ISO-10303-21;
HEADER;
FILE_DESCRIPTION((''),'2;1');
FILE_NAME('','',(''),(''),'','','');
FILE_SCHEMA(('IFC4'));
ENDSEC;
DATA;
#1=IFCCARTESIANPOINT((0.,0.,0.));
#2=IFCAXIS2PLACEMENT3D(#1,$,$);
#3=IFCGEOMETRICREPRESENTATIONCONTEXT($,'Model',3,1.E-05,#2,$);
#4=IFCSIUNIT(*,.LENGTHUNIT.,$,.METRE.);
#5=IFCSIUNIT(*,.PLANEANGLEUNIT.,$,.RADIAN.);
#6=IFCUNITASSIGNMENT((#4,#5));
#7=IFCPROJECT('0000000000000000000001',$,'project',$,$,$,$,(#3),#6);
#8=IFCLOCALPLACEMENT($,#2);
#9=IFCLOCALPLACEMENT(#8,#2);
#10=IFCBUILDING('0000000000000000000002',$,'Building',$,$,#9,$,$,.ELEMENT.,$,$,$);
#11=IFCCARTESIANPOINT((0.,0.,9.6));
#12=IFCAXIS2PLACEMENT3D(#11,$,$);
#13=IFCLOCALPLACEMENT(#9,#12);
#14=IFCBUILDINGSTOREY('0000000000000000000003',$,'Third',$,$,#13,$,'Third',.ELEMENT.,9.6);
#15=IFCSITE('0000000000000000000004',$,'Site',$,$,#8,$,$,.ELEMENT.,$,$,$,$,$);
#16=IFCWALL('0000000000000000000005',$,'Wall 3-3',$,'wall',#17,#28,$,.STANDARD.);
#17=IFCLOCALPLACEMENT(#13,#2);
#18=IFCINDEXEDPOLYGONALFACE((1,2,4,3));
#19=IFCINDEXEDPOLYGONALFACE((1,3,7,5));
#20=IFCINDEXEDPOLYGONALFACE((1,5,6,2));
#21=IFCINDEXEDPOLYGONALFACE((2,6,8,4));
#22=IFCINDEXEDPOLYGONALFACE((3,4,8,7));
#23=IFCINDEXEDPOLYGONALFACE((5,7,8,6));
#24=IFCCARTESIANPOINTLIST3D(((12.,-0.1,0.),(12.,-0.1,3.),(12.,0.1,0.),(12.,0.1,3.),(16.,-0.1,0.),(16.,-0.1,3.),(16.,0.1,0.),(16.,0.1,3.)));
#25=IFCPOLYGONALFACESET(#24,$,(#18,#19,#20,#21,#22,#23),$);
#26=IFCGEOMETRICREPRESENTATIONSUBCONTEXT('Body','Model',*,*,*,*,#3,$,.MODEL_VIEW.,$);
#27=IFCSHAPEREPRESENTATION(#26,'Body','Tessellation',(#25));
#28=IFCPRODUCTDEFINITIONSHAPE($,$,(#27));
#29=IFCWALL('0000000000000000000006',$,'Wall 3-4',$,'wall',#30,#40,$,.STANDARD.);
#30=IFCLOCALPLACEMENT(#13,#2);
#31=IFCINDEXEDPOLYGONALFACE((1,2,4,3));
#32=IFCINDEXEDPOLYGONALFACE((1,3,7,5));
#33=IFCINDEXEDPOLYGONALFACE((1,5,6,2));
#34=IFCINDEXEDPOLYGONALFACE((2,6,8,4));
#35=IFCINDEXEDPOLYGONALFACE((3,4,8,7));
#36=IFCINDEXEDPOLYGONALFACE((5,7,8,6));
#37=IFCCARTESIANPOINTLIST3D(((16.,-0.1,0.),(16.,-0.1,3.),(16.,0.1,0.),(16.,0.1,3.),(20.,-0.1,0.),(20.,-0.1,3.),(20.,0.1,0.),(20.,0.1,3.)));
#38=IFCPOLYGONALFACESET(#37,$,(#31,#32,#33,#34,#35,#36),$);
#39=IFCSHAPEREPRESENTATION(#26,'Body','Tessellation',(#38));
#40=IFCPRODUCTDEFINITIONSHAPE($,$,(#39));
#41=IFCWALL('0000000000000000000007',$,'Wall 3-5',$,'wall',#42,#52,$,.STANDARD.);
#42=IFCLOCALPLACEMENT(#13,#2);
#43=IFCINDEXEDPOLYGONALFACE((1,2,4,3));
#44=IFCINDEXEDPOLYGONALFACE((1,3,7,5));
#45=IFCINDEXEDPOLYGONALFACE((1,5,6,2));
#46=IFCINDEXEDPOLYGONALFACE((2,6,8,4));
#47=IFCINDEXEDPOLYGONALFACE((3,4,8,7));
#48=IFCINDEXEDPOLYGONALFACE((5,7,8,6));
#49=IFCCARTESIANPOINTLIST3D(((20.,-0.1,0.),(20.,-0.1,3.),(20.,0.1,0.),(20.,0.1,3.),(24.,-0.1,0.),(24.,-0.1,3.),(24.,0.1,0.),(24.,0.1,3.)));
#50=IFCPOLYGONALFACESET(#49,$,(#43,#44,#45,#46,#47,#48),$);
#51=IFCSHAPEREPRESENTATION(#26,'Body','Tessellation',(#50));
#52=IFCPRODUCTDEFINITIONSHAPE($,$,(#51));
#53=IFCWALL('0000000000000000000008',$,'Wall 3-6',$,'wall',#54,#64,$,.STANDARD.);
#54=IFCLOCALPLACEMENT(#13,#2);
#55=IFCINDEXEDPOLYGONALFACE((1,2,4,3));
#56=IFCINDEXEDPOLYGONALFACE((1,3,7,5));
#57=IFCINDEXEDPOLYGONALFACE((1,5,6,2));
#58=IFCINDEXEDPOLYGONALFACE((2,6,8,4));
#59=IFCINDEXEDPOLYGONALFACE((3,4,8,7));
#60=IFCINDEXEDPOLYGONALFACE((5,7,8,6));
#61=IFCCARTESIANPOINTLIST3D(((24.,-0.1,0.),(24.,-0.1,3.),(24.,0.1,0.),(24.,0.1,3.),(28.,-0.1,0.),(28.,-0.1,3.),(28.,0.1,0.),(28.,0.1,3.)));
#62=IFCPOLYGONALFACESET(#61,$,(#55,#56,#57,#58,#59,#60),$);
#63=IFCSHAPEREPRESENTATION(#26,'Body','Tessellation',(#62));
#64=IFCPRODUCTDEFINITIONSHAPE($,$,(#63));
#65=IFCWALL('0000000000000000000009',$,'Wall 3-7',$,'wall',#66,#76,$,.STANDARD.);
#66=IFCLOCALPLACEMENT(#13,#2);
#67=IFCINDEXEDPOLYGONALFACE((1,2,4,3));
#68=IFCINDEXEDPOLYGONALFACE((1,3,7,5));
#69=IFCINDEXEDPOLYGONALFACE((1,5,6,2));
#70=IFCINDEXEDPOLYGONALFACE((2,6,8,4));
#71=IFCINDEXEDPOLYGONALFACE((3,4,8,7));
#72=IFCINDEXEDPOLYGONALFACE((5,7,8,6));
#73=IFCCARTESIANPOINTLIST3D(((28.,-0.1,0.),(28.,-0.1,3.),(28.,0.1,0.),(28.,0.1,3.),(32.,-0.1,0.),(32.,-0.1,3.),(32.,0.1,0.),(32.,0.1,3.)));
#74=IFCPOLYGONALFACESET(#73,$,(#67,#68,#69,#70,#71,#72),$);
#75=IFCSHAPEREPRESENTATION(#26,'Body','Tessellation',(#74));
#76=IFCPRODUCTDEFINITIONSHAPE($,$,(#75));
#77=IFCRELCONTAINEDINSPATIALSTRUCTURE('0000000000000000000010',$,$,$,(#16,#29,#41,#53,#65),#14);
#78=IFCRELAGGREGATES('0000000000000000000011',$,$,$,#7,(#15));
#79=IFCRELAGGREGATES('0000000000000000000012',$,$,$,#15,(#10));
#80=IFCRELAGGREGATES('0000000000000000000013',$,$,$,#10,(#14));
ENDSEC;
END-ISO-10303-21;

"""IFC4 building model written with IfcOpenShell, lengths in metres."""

from ifc_helpers import new_model, si_unit, frame, frame_2d, origin, place, context, subcontext, project, spatial, rectangle, extrude, element, save


model = new_model("IFC4")

# Units and contexts
model_context = context("Model", 3, precision=1e-05, world=origin())
body_context = subcontext(model_context, "Body", "Model", "MODEL_VIEW")
ifc_project = project(units=[si_unit("LENGTHUNIT", "METRE"), si_unit("PLANEANGLEUNIT", "RADIAN")], contexts=[model_context])

# Site, building, storey
site_placement = place(None, origin())
site = spatial("IfcSite", under=ifc_project, at=site_placement, Name="Site", CompositionType="ELEMENT")
building_placement = place(site_placement, origin())
building = spatial("IfcBuilding", under=site, at=building_placement, Name="Building", CompositionType="ELEMENT")
storey_placement = place(building_placement, frame((0.0, 0.0, 9.6)))
storey = spatial("IfcBuildingStorey", under=building, at=storey_placement, Name="Third", LongName="Third", CompositionType="ELEMENT", Elevation=9.6)

# Walls
for number, where, z_axis, x_axis, name in (
    (1, (12.0, 0.0, 0.0), (0.0, 0.0, 1.0), (1.0, 0.0, 0.0), "Wall 3-3"),
    (2, (16.0, 0.0, 0.0), (0.0, 0.0, 1.0), (1.0, 0.0, 0.0), "Wall 3-4"),
    (3, (20.0, 0.0, 0.0), (0.0, 0.0, 1.0), (1.0, 0.0, 0.0), "Wall 3-5"),
    (4, (24.0, 0.0, 0.0), (0.0, 0.0, 1.0), (1.0, 0.0, 0.0), "Wall 3-6"),
    (5, (28.0, 0.0, 0.0), (0.0, 0.0, 1.0), (1.0, 0.0, 0.0), "Wall 3-7"),
):
    element("IfcWall", number, at=place(storey_placement, frame(where, z_axis=z_axis, x_axis=x_axis)), inside=storey, Name=name, ObjectType="wall", PredefinedType="STANDARD", context=body_context, shape_type="SweptSolid", body=[
        extrude(rectangle(XDim=4.0, YDim=0.2, at=frame_2d((2.0, 0.0))), origin(), (0.0, 0.0, 1.0), 3.0),
    ])

save(model, "model.ifc")
